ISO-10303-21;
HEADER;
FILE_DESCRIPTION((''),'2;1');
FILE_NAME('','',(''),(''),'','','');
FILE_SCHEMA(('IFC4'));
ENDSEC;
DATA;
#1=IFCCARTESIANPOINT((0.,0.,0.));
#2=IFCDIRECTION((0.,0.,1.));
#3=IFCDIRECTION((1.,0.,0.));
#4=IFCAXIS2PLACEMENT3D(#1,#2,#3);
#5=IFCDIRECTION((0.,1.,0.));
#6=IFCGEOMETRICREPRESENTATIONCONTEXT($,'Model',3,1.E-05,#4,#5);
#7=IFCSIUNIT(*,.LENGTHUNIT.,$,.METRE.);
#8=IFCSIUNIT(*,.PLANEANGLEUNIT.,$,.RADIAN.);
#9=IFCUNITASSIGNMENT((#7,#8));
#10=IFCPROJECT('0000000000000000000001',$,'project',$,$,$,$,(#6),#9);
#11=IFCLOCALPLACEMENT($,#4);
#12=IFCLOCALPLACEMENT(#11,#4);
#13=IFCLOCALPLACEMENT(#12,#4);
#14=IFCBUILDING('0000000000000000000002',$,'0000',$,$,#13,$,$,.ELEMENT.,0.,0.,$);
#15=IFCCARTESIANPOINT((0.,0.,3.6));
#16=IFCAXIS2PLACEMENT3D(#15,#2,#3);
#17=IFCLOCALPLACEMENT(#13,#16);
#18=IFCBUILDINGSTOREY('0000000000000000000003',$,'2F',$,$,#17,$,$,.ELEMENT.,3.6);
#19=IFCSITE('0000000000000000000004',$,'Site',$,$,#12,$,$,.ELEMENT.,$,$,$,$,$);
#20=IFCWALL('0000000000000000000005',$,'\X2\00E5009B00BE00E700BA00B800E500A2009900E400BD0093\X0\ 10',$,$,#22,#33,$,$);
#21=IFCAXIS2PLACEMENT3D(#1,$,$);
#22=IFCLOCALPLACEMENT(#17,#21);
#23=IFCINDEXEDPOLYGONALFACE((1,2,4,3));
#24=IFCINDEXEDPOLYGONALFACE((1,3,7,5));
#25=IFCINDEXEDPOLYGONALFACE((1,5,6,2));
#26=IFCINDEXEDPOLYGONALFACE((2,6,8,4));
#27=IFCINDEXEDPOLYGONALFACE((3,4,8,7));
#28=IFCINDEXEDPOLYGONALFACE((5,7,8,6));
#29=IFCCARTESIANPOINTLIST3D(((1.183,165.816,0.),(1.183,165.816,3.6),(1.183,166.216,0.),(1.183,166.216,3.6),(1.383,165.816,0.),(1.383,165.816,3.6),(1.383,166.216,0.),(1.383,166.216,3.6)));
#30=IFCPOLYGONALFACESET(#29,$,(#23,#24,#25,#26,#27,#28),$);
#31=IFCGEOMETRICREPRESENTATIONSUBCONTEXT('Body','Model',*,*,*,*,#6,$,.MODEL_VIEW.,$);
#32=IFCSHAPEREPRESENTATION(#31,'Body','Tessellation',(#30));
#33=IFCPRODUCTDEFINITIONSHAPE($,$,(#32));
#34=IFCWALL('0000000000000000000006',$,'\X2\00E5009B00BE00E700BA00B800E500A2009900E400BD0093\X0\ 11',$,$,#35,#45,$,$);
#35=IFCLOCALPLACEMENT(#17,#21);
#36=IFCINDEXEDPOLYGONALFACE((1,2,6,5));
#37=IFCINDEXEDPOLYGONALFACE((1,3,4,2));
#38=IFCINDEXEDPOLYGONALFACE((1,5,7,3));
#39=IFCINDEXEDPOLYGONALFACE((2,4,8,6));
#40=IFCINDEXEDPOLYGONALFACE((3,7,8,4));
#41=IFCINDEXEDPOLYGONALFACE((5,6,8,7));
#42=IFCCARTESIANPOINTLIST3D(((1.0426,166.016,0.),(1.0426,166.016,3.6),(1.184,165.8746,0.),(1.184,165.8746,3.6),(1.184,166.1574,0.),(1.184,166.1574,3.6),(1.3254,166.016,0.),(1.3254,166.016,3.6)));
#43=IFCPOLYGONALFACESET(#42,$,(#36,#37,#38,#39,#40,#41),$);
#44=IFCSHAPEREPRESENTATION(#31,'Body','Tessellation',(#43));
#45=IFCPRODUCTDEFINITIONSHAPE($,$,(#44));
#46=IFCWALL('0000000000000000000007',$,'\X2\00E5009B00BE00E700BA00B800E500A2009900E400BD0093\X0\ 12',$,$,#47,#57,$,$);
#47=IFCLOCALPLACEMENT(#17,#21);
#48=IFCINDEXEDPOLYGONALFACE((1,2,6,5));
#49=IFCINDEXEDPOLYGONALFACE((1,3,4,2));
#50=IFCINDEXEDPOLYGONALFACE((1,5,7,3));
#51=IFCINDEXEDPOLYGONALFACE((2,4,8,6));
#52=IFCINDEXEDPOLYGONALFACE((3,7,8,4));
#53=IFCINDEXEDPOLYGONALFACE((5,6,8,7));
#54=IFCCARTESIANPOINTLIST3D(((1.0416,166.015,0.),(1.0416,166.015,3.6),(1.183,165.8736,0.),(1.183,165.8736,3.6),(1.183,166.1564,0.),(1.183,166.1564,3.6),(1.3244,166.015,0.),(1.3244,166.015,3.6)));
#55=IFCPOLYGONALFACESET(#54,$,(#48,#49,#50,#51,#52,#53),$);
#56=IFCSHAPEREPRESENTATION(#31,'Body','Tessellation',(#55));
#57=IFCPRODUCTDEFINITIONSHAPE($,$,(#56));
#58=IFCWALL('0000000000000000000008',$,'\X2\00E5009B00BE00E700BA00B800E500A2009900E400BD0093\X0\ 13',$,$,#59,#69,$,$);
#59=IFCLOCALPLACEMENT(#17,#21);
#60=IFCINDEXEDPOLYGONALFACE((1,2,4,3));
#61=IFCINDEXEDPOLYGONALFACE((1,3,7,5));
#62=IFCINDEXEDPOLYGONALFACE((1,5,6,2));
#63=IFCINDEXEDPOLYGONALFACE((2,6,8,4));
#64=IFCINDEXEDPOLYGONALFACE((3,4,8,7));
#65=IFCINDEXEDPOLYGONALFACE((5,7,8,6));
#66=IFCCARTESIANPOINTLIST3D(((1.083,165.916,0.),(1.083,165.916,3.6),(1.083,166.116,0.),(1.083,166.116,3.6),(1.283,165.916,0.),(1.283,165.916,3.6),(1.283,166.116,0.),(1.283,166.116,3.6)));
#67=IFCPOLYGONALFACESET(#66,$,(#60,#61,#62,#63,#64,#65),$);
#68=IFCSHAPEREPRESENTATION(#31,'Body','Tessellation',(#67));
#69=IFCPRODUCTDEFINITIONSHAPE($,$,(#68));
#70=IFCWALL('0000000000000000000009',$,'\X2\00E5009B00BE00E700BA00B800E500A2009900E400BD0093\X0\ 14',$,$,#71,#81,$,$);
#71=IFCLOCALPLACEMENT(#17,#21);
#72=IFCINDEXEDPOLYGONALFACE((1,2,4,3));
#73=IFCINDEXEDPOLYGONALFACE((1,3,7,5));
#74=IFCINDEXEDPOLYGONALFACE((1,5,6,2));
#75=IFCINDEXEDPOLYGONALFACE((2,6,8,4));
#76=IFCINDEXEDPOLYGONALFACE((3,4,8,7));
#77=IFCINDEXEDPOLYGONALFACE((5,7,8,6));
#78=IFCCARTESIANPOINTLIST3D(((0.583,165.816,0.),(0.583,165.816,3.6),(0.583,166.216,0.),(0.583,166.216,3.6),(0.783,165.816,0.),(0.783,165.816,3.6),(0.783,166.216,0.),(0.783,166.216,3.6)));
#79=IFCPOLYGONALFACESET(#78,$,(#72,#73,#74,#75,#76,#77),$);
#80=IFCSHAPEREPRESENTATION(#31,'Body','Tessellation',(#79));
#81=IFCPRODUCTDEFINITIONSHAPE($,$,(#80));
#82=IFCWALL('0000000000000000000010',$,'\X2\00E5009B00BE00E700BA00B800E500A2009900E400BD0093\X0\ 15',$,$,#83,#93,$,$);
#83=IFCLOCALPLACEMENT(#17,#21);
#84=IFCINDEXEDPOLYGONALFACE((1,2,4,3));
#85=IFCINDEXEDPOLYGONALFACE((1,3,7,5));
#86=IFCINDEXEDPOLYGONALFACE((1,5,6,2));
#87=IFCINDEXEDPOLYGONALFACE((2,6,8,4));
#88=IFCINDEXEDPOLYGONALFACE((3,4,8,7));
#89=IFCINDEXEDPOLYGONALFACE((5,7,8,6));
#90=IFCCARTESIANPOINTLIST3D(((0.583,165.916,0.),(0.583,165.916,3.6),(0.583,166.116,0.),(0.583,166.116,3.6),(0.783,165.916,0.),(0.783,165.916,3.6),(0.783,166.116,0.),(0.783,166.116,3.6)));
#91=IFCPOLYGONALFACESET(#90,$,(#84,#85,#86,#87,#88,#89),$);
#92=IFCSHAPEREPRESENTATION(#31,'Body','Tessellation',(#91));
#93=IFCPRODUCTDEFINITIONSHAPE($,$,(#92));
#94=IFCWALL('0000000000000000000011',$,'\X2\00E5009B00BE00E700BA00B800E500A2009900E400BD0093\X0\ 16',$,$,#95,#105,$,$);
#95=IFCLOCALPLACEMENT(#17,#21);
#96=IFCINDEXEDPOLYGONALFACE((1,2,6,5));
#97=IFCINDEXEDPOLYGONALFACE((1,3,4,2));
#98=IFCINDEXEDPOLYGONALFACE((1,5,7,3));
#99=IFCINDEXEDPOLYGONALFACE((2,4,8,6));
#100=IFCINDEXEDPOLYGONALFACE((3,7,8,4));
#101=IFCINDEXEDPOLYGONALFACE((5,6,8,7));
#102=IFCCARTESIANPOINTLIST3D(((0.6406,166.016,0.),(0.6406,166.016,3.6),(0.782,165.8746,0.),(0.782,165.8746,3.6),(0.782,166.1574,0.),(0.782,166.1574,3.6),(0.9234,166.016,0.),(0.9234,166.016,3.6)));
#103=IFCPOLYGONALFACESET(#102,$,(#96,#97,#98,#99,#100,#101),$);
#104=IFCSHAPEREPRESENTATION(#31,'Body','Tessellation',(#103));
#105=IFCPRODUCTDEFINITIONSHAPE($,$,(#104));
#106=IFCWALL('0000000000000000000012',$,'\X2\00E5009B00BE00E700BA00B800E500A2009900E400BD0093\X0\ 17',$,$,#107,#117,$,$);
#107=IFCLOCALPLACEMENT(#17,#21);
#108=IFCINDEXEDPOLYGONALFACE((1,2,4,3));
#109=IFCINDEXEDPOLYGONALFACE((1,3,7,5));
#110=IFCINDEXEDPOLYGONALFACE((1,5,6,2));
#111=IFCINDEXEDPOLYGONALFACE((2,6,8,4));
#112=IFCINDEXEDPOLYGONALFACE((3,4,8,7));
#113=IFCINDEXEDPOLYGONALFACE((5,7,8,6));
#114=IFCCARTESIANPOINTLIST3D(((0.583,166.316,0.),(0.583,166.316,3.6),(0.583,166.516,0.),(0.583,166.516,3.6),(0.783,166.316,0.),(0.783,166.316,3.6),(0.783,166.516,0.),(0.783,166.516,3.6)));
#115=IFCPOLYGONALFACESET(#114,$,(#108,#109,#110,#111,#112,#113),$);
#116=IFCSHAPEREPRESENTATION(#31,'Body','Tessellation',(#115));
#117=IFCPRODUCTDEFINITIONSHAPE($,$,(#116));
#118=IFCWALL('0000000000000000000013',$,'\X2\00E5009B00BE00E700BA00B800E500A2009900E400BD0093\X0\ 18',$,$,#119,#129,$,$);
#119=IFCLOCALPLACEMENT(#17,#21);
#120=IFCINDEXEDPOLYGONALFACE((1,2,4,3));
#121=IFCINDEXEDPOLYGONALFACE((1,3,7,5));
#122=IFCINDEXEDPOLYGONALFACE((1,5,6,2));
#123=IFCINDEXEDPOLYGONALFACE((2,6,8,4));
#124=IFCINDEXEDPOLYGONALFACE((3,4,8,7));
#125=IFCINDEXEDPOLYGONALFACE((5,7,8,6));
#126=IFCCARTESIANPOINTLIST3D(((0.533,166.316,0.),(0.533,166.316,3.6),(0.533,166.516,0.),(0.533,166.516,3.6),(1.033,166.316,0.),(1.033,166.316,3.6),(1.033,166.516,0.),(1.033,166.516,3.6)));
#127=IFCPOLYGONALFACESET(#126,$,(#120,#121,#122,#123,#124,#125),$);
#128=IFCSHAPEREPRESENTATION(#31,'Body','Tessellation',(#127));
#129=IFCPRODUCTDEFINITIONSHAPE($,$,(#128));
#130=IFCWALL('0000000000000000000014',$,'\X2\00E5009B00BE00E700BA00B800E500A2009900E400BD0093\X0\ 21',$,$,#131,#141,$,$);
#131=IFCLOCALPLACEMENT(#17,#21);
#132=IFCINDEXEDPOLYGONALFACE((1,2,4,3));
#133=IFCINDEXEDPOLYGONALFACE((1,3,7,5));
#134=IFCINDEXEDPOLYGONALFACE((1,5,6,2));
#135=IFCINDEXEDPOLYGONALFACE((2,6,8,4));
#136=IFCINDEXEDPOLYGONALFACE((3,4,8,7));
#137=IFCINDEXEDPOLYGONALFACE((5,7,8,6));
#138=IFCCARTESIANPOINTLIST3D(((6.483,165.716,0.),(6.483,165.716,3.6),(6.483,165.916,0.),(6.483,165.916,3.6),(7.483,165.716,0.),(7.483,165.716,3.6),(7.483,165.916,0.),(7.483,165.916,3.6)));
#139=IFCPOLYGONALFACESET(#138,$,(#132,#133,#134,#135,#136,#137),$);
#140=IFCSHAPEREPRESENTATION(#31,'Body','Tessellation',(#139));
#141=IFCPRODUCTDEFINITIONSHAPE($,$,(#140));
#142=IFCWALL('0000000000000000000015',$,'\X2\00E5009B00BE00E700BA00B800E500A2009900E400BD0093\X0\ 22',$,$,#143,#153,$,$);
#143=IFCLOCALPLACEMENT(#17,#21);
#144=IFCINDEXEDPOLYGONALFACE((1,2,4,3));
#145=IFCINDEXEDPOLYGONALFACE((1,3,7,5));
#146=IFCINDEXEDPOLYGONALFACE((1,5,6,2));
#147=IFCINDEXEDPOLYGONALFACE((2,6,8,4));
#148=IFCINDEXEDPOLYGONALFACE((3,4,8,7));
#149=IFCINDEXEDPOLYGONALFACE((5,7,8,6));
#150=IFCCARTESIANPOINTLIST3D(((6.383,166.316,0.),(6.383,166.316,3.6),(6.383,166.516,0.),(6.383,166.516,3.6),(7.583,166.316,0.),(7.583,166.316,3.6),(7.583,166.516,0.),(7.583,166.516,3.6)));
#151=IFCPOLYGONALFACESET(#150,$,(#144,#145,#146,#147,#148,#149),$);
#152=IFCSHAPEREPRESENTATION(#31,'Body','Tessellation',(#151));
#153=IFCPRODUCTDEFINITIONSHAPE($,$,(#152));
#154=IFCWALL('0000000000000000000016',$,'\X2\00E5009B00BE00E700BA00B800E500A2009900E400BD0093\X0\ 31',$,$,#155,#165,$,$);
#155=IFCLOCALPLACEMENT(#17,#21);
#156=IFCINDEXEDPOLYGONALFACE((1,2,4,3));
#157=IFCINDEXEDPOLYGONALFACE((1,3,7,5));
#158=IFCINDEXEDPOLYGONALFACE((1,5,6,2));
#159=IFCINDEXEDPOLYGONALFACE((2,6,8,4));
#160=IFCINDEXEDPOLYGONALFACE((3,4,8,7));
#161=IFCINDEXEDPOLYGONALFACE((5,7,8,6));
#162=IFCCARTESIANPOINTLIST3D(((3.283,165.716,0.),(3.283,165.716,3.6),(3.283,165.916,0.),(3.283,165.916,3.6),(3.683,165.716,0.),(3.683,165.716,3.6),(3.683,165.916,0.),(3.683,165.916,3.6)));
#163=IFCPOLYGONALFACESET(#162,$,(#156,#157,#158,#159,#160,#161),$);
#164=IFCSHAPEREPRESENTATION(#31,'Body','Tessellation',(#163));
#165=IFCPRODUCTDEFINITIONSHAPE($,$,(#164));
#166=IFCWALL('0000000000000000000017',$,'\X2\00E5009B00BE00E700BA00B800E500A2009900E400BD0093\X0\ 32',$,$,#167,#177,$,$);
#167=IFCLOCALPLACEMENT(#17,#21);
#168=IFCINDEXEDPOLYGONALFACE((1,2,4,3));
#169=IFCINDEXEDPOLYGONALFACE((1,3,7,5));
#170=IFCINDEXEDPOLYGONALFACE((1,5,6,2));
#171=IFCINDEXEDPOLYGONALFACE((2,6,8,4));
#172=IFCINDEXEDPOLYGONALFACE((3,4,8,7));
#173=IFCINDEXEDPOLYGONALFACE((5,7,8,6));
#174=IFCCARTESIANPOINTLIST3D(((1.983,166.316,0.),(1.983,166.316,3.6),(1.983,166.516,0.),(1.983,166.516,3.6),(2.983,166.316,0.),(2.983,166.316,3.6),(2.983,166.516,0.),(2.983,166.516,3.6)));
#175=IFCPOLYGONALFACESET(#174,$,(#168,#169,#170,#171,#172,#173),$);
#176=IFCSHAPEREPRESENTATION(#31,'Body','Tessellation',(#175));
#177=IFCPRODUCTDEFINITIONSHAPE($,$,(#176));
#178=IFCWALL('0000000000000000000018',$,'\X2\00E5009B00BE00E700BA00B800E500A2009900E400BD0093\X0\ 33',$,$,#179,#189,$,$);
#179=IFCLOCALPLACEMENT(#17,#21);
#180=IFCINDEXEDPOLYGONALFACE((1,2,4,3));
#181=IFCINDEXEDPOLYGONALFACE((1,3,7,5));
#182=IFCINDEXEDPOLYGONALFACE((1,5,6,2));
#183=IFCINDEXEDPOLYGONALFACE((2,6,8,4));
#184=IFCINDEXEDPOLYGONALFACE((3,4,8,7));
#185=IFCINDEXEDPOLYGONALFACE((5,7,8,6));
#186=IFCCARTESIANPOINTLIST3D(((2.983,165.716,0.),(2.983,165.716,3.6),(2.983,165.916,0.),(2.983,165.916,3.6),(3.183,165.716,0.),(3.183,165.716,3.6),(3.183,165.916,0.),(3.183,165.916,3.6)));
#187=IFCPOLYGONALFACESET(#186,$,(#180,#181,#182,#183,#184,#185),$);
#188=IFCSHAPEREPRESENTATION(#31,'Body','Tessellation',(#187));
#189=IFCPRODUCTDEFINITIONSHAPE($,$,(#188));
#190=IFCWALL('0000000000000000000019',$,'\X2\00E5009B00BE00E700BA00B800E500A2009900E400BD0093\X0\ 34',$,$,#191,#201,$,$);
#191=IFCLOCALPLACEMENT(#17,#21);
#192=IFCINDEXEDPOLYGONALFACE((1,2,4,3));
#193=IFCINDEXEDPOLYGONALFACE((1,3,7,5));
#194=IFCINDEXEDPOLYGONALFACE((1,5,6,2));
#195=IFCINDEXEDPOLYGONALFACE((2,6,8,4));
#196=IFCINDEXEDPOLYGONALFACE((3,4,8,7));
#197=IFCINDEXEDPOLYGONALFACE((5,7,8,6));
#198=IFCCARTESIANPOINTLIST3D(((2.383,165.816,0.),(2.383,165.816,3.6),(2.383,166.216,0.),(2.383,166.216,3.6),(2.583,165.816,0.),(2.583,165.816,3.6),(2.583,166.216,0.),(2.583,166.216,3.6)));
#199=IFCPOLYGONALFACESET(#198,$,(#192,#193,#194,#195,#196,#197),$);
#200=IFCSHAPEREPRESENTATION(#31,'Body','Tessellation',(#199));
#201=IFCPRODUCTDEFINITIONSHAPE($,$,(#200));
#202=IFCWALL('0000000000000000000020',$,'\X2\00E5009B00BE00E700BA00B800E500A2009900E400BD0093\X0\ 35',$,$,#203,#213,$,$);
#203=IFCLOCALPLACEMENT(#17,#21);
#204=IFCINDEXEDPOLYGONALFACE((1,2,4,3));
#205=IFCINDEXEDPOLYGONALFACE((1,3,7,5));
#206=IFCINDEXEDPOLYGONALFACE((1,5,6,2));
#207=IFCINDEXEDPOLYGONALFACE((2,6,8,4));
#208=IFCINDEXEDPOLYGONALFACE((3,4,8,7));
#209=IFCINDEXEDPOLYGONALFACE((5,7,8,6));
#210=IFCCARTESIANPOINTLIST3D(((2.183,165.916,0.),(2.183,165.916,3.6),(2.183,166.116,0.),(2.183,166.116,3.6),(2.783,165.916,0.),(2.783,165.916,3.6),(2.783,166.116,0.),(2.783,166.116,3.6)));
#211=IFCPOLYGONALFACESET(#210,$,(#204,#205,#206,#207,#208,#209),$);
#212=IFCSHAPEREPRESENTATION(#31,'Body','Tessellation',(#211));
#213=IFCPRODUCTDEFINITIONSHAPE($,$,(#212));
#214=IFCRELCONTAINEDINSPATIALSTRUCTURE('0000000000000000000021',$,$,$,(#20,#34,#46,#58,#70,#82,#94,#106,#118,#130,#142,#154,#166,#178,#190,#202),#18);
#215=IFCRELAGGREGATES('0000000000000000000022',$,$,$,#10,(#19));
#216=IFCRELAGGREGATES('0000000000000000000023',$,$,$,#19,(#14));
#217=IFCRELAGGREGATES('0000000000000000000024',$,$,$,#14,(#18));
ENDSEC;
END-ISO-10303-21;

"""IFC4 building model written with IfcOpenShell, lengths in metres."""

from ifc_helpers import new_model, si_unit, direction, frame, frame_2d, origin_with_axes, place, context, subcontext, project, spatial, rectangle, extrude, element, save


model = new_model("IFC4")

# Units and contexts
model_context = context("Model", 3, precision=1e-05, world=origin_with_axes(), true_north=direction((0.0, 1.0, 0.0)))
body_context = subcontext(model_context, "Body", "Model", "MODEL_VIEW")
ifc_project = project(units=[si_unit("LENGTHUNIT", "METRE"), si_unit("PLANEANGLEUNIT", "RADIAN")], contexts=[model_context])

# Site, building, storey
placement = place(None, origin_with_axes())
site_placement = place(placement, origin_with_axes())
site = spatial("IfcSite", under=ifc_project, at=site_placement, Name="Site", CompositionType="ELEMENT")
building_placement = place(site_placement, origin_with_axes())
building = spatial("IfcBuilding", under=site, at=building_placement, Name="0000", CompositionType="ELEMENT", ElevationOfRefHeight=0.0, ElevationOfTerrain=0.0)
storey_placement = place(building_placement, frame((0.0, 0.0, 3.6), z_axis=(0.0, 0.0, 1.0), x_axis=(1.0, 0.0, 0.0)))
storey = spatial("IfcBuildingStorey", under=building, at=storey_placement, Name="2F", CompositionType="ELEMENT", Elevation=3.6)

# Walls
wall_1_placement = place(storey_placement, frame((1.283, 166.016, 0.0), z_axis=(0.0, 0.0, 1.0), x_axis=(0.0, 1.0, 0.0)))
element("IfcWall", 1, at=wall_1_placement, inside=storey, Name="å\u009b¾çº¸å¢\u0099ä½\u0093 10", context=body_context, shape_type="SweptSolid", body=[
    extrude(rectangle(XDim=0.4, YDim=0.2, at=frame_2d((0.0, 0.0), x_axis=(1.0, 0.0, 0.0))), frame((0.0, 0.0, 0.0), z_axis=(0.0, 0.0, 1.0)), (0.0, 0.0, 1.0), 3.6),
])
for number, where, z_axis, x_axis, name in (
    (2, (1.184, 166.016, 0.0), (0.0, 0.0, 1.0), (-0.707107, -0.707107, 0.0), "å\u009b¾çº¸å¢\u0099ä½\u0093 11"),
    (3, (1.183, 166.015, 0.0), (0.0, 0.0, 1.0), (0.707107, 0.707107, 0.0), "å\u009b¾çº¸å¢\u0099ä½\u0093 12"),
    (4, (1.183, 166.016, 0.0), (0.0, 0.0, 1.0), (1.0, 0.0, 0.0), "å\u009b¾çº¸å¢\u0099ä½\u0093 13"),
):
    element("IfcWall", number, at=place(storey_placement, frame(where, z_axis=z_axis, x_axis=x_axis)), inside=storey, Name=name, context=body_context, shape_type="SweptSolid", body=[
        extrude(rectangle(XDim=0.2, YDim=0.2, at=frame_2d((0.0, 0.0), x_axis=(1.0, 0.0, 0.0))), frame((0.0, 0.0, 0.0), z_axis=(0.0, 0.0, 1.0)), (0.0, 0.0, 1.0), 3.6),
    ])
wall_2_placement = place(storey_placement, frame((0.683, 166.016, 0.0), z_axis=(0.0, 0.0, 1.0), x_axis=(0.0, 1.0, 0.0)))
element("IfcWall", 5, at=wall_2_placement, inside=storey, Name="å\u009b¾çº¸å¢\u0099ä½\u0093 14", context=body_context, shape_type="SweptSolid", body=[
    extrude(rectangle(XDim=0.4, YDim=0.2, at=frame_2d((0.0, 0.0), x_axis=(1.0, 0.0, 0.0))), frame((0.0, 0.0, 0.0), z_axis=(0.0, 0.0, 1.0)), (0.0, 0.0, 1.0), 3.6),
])
for number, where, z_axis, x_axis, name in (
    (6, (0.683, 166.016, 0.0), (0.0, 0.0, 1.0), (1.0, 0.0, 0.0), "å\u009b¾çº¸å¢\u0099ä½\u0093 15"),
    (7, (0.782, 166.016, 0.0), (0.0, 0.0, 1.0), (0.707107, -0.707107, 0.0), "å\u009b¾çº¸å¢\u0099ä½\u0093 16"),
    (8, (0.683, 166.416, 0.0), (0.0, 0.0, 1.0), (1.0, 0.0, 0.0), "å\u009b¾çº¸å¢\u0099ä½\u0093 17"),
):
    element("IfcWall", number, at=place(storey_placement, frame(where, z_axis=z_axis, x_axis=x_axis)), inside=storey, Name=name, context=body_context, shape_type="SweptSolid", body=[
        extrude(rectangle(XDim=0.2, YDim=0.2, at=frame_2d((0.0, 0.0), x_axis=(1.0, 0.0, 0.0))), frame((0.0, 0.0, 0.0), z_axis=(0.0, 0.0, 1.0)), (0.0, 0.0, 1.0), 3.6),
    ])
wall_3_placement = place(storey_placement, frame((0.783, 166.416, 0.0), z_axis=(0.0, 0.0, 1.0), x_axis=(1.0, 0.0, 0.0)))
element("IfcWall", 9, at=wall_3_placement, inside=storey, Name="å\u009b¾çº¸å¢\u0099ä½\u0093 18", context=body_context, shape_type="SweptSolid", body=[
    extrude(rectangle(XDim=0.5, YDim=0.2, at=frame_2d((0.0, 0.0), x_axis=(1.0, 0.0, 0.0))), frame((0.0, 0.0, 0.0), z_axis=(0.0, 0.0, 1.0)), (0.0, 0.0, 1.0), 3.6),
])
wall_4_placement = place(storey_placement, frame((6.983, 165.816, 0.0), z_axis=(0.0, 0.0, 1.0), x_axis=(1.0, 0.0, 0.0)))
element("IfcWall", 10, at=wall_4_placement, inside=storey, Name="å\u009b¾çº¸å¢\u0099ä½\u0093 21", context=body_context, shape_type="SweptSolid", body=[
    extrude(rectangle(XDim=1.0, YDim=0.2, at=frame_2d((0.0, 0.0), x_axis=(1.0, 0.0, 0.0))), frame((0.0, 0.0, 0.0), z_axis=(0.0, 0.0, 1.0)), (0.0, 0.0, 1.0), 3.6),
])
wall_5_placement = place(storey_placement, frame((6.983, 166.416, 0.0), z_axis=(0.0, 0.0, 1.0), x_axis=(1.0, 0.0, 0.0)))
element("IfcWall", 11, at=wall_5_placement, inside=storey, Name="å\u009b¾çº¸å¢\u0099ä½\u0093 22", context=body_context, shape_type="SweptSolid", body=[
    extrude(rectangle(XDim=1.2, YDim=0.2, at=frame_2d((0.0, 0.0), x_axis=(1.0, 0.0, 0.0))), frame((0.0, 0.0, 0.0), z_axis=(0.0, 0.0, 1.0)), (0.0, 0.0, 1.0), 3.6),
])
wall_6_placement = place(storey_placement, frame((3.483, 165.816, 0.0), z_axis=(0.0, 0.0, 1.0), x_axis=(-1.0, 0.0, 0.0)))
element("IfcWall", 12, at=wall_6_placement, inside=storey, Name="å\u009b¾çº¸å¢\u0099ä½\u0093 31", context=body_context, shape_type="SweptSolid", body=[
    extrude(rectangle(XDim=0.4, YDim=0.2, at=frame_2d((0.0, 0.0), x_axis=(1.0, 0.0, 0.0))), frame((0.0, 0.0, 0.0), z_axis=(0.0, 0.0, 1.0)), (0.0, 0.0, 1.0), 3.6),
])
wall_7_placement = place(storey_placement, frame((2.483, 166.416, 0.0), z_axis=(0.0, 0.0, 1.0), x_axis=(1.0, 0.0, 0.0)))
element("IfcWall", 13, at=wall_7_placement, inside=storey, Name="å\u009b¾çº¸å¢\u0099ä½\u0093 32", context=body_context, shape_type="SweptSolid", body=[
    extrude(rectangle(XDim=1.0, YDim=0.2, at=frame_2d((0.0, 0.0), x_axis=(1.0, 0.0, 0.0))), frame((0.0, 0.0, 0.0), z_axis=(0.0, 0.0, 1.0)), (0.0, 0.0, 1.0), 3.6),
])
wall_8_placement = place(storey_placement, frame((3.083, 165.816, 0.0), z_axis=(0.0, 0.0, 1.0), x_axis=(0.0, 1.0, 0.0)))
element("IfcWall", 14, at=wall_8_placement, inside=storey, Name="å\u009b¾çº¸å¢\u0099ä½\u0093 33", context=body_context, shape_type="SweptSolid", body=[
    extrude(rectangle(XDim=0.2, YDim=0.2, at=frame_2d((0.0, 0.0), x_axis=(1.0, 0.0, 0.0))), frame((0.0, 0.0, 0.0), z_axis=(0.0, 0.0, 1.0)), (0.0, 0.0, 1.0), 3.6),
])
wall_9_placement = place(storey_placement, frame((2.483, 166.016, 0.0), z_axis=(0.0, 0.0, 1.0), x_axis=(0.0, 1.0, 0.0)))
element("IfcWall", 15, at=wall_9_placement, inside=storey, Name="å\u009b¾çº¸å¢\u0099ä½\u0093 34", context=body_context, shape_type="SweptSolid", body=[
    extrude(rectangle(XDim=0.4, YDim=0.2, at=frame_2d((0.0, 0.0), x_axis=(1.0, 0.0, 0.0))), frame((0.0, 0.0, 0.0), z_axis=(0.0, 0.0, 1.0)), (0.0, 0.0, 1.0), 3.6),
])
for number, where, z_axis, x_axis, name in (
    (16, (2.483, 166.016, 0.0), (0.0, 0.0, 1.0), (1.0, 0.0, 0.0), "å\u009b¾çº¸å¢\u0099ä½\u0093 35"),
):
    element("IfcWall", number, at=place(storey_placement, frame(where, z_axis=z_axis, x_axis=x_axis)), inside=storey, Name=name, context=body_context, shape_type="SweptSolid", body=[
        extrude(rectangle(XDim=0.6, YDim=0.2, at=frame_2d((0.0, 0.0), x_axis=(1.0, 0.0, 0.0))), frame((0.0, 0.0, 0.0), z_axis=(0.0, 0.0, 1.0)), (0.0, 0.0, 1.0), 3.6),
    ])

save(model, "model.ifc")
